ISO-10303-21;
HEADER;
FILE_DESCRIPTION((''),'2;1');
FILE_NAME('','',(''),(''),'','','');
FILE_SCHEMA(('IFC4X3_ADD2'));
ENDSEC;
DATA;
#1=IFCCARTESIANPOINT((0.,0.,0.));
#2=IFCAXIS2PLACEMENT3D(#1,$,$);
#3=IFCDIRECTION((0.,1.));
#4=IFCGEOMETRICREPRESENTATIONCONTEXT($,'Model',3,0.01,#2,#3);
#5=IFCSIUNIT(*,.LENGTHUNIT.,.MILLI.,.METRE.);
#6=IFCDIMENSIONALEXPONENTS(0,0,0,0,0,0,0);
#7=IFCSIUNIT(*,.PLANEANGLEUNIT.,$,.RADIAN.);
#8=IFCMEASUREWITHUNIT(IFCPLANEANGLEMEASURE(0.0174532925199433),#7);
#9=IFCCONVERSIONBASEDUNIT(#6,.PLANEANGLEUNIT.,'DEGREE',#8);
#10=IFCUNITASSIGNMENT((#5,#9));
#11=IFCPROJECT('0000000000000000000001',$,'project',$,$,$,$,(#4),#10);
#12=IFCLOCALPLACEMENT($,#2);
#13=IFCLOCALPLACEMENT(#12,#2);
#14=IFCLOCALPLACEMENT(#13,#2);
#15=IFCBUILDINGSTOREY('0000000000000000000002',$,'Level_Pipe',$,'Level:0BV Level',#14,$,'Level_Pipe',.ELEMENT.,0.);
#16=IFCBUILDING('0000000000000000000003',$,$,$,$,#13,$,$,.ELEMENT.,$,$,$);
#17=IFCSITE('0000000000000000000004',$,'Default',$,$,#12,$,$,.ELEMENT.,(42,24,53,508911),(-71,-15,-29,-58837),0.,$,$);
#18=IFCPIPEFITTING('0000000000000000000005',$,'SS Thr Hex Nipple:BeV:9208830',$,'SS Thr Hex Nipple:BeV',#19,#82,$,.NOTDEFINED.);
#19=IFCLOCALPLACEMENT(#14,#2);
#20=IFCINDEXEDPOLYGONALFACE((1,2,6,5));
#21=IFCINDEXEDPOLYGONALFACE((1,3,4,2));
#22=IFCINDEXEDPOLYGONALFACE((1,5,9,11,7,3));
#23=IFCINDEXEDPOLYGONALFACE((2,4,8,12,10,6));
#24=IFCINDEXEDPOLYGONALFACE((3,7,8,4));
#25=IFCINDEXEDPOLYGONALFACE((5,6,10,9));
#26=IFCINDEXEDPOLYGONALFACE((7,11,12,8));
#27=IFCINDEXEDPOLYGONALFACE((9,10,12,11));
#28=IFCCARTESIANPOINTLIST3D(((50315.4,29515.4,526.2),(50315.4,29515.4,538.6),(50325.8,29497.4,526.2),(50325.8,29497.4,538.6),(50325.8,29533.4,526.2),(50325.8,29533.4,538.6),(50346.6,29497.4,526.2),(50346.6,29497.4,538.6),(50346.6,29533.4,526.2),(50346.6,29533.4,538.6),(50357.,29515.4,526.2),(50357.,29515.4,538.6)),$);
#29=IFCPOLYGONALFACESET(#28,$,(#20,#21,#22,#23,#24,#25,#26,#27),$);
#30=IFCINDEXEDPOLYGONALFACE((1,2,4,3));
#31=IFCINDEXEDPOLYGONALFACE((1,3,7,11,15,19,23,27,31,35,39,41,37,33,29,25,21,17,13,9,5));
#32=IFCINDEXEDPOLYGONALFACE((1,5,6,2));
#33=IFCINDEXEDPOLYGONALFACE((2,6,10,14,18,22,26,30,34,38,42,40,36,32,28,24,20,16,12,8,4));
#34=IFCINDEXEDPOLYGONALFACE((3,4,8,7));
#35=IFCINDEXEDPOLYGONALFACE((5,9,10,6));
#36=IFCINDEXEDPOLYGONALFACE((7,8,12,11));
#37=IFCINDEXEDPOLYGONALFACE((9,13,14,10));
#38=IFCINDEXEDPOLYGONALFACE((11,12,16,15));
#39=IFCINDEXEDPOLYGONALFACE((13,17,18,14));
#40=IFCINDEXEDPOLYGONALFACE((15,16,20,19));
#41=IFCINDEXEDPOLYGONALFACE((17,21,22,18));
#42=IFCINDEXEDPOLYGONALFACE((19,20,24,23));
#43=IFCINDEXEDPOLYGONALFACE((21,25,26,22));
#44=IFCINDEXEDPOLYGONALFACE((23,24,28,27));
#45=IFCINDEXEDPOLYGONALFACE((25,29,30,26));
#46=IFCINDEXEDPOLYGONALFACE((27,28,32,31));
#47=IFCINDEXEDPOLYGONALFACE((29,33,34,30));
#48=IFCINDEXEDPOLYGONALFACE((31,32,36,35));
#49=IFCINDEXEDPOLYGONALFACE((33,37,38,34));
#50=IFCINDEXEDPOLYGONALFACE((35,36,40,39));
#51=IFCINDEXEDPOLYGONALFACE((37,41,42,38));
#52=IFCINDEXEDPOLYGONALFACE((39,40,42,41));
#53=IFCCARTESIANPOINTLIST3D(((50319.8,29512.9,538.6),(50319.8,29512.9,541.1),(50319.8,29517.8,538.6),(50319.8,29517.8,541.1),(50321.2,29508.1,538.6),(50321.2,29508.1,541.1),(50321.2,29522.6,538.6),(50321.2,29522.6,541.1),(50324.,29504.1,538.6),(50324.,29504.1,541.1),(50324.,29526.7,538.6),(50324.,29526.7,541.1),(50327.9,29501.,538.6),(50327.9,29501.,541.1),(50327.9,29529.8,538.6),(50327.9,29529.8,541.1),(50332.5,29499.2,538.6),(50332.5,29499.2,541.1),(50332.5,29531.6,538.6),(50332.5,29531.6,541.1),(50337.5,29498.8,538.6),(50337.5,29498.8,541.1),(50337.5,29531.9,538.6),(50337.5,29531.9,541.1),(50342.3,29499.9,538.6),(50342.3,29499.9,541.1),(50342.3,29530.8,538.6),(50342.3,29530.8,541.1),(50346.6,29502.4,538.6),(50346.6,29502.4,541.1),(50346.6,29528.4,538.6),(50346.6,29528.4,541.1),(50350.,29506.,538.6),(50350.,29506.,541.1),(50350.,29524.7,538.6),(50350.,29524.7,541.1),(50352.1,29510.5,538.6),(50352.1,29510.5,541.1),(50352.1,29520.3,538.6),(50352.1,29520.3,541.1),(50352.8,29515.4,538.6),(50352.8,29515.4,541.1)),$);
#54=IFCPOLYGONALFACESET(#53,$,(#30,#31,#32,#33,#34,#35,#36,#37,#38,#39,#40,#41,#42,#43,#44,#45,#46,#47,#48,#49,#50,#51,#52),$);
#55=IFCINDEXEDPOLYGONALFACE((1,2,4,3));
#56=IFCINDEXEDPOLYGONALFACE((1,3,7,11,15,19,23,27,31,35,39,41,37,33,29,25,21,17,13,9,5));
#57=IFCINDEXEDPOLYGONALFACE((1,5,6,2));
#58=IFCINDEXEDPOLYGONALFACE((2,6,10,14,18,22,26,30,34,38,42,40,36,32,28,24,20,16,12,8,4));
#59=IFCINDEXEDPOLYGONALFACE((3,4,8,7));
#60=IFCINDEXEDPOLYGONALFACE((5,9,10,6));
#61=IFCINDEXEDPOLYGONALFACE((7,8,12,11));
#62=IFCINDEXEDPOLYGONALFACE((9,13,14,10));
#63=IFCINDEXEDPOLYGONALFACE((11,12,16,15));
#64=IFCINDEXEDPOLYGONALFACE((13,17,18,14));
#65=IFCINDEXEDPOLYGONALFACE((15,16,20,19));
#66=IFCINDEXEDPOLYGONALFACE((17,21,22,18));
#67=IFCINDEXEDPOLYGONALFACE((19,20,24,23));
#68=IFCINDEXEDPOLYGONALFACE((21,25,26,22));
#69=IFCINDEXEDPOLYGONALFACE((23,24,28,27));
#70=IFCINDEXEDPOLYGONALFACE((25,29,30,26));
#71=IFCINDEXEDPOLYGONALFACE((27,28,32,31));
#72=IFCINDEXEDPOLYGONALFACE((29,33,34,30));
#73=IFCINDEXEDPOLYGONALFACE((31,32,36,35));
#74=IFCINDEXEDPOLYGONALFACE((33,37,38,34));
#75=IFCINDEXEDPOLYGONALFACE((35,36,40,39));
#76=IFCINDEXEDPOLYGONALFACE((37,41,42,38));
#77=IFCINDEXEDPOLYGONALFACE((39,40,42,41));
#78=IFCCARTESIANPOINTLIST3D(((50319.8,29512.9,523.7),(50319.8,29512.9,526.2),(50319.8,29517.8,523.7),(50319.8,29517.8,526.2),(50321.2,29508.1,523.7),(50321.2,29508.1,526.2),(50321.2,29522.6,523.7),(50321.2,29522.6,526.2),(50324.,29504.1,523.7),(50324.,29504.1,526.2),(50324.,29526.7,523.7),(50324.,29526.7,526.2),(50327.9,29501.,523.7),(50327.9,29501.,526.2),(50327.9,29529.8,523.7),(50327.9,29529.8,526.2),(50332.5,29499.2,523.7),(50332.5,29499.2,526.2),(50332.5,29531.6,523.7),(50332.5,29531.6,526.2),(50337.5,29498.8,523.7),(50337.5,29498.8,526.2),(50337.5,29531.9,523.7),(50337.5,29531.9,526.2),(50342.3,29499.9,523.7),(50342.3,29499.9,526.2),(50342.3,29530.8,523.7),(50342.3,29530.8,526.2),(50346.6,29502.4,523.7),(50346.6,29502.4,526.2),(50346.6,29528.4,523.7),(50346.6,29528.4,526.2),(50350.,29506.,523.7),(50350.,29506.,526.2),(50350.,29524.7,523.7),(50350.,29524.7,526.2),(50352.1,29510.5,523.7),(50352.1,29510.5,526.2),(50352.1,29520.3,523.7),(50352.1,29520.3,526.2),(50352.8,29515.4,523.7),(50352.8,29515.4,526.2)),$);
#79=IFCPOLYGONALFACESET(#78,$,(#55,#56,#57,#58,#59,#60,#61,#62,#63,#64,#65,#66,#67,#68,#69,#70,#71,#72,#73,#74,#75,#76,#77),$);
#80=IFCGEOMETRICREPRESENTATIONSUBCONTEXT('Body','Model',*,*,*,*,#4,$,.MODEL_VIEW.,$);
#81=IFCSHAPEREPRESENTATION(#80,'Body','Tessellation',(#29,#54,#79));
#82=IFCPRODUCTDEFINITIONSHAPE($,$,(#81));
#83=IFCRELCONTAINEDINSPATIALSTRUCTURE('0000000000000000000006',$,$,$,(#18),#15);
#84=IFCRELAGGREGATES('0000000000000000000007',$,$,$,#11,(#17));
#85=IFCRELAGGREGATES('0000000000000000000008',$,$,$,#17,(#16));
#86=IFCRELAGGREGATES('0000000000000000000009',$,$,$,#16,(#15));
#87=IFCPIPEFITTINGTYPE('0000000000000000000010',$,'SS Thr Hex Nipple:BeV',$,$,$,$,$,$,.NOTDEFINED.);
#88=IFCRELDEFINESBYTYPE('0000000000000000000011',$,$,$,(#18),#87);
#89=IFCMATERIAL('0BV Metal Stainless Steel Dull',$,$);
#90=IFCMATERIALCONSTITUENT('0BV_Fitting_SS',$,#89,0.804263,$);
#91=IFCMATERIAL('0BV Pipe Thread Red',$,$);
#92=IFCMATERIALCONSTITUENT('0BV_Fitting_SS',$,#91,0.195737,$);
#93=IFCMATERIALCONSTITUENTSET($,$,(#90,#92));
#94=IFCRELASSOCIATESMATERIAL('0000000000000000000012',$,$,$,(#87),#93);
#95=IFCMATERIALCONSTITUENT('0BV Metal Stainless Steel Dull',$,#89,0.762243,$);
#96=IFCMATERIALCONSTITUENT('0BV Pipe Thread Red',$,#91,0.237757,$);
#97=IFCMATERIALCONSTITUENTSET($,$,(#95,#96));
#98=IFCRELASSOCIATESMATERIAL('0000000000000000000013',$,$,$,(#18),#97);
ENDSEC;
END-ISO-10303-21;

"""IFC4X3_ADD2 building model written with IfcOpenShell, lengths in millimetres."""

from ifc_helpers import new_model, entity, si_unit, converted_unit, direction, frame, frame_2d, origin, place, context, subcontext, project, spatial, polyline, circle, outline, extrude, source, transform, mapped, material, constituent, constituent_set, type_object, type_shapes, element, save


model = new_model("IFC4X3_ADD2")

# Units and contexts
model_context = context("Model", 3, precision=0.01, world=origin(), true_north=direction((0.0, 1.0)))
body_context = subcontext(model_context, "Body", "Model", "MODEL_VIEW")
ifc_project = project(units=[si_unit("LENGTHUNIT", "METRE", prefix="MILLI"), converted_unit("PLANEANGLEUNIT", "DEGREE", entity("IfcPlaneAngleMeasure", 0.0174532925199433), si_unit("PLANEANGLEUNIT", "RADIAN"), dimensions=[0, 0, 0, 0, 0, 0, 0])], contexts=[model_context])

# Site, building, storey
site_placement = place(None, origin())
site = spatial("IfcSite", under=ifc_project, at=site_placement, Name="Default", CompositionType="ELEMENT", RefLatitude=(42, 24, 53, 508911), RefLongitude=(-71, -15, -29, -58837), RefElevation=0.0)
building_placement = place(site_placement, origin())
building = spatial("IfcBuilding", under=site, at=building_placement, CompositionType="ELEMENT")
storey_placement = place(building_placement, origin())
storey = spatial("IfcBuildingStorey", under=building, at=storey_placement, Name="Level_Pipe", ObjectType="Level:0BV Level", LongName="Level_Pipe", CompositionType="ELEMENT", Elevation=0.0)

# Shared definitions
ifc_material_1 = material(Name="0BV Metal Stainless Steel Dull")

# Pipe fitting
ifc_material_2 = material(Name="0BV Pipe Thread Red")
ifc_constituent_1 = constituent(ifc_material_1, Name="0BV Metal Stainless Steel Dull", fraction=0.762243)
ifc_constituent_2 = constituent(ifc_material_2, Name="0BV Pipe Thread Red", fraction=0.237757)
ifc_constituent_set_1 = constituent_set(constituents=[ifc_constituent_1, ifc_constituent_2])
ifc_constituent_3 = constituent(ifc_material_1, Name="0BV_Fitting_SS", fraction=0.804263)
ifc_constituent_4 = constituent(ifc_material_2, Name="0BV_Fitting_SS", fraction=0.195737)
ifc_constituent_set_2 = constituent_set(constituents=[ifc_constituent_3, ifc_constituent_4])
pipe_fitting_type_1 = type_object("IfcPipeFittingType", Name="SS Thr Hex Nipple:BeV", PredefinedType="NOTDEFINED", material=ifc_constituent_set_2)
shared_shape_1 = source(origin(), body_context, "Body", "SweptSolid", [
    extrude(outline(polyline([(-10.4, -18.0), (10.4, -18.0), (20.8, 0.0), (10.4, 18.0), (-10.4, 18.0), (-20.8, 0.0), (-10.4, -18.0)])), frame((-6.2, 0.0, 0.0), z_axis=(1.0, 0.0, 0.0), x_axis=(0.0, -0.5, -0.866025)), (0.0, 0.0, 1.0), 12.4),
    extrude(circle(Radius=16.6, at=frame_2d((0.0, 0.0), x_axis=(1.0, 0.0))), frame((6.2, 0.0, 0.0), z_axis=(1.0, 0.0, 0.0), x_axis=(0.0, 1.0, 0.0)), (0.0, 0.0, 1.0), 2.5),
    extrude(circle(Radius=16.6, at=frame_2d((0.0, 0.0), x_axis=(1.0, 0.0))), frame((-8.7, 0.0, 0.0), z_axis=(1.0, 0.0, 0.0), x_axis=(0.0, 1.0, 0.0)), (0.0, 0.0, 1.0), 2.5),
])
type_shapes(pipe_fitting_type_1, [shared_shape_1])
pipe_fitting_1_placement = place(storey_placement, frame((50336.2, 29515.4, 532.4), z_axis=(0.0, 1.0, 0.0), x_axis=(0.0, 0.0, 1.0)))
element("IfcPipeFitting", 1, at=pipe_fitting_1_placement, inside=storey, type_object=pipe_fitting_type_1, material=ifc_constituent_set_1, Name="SS Thr Hex Nipple:BeV:9208830", ObjectType="SS Thr Hex Nipple:BeV", PredefinedType="NOTDEFINED", context=body_context, shape_type="MappedRepresentation", body=[
    mapped(shared_shape_1, transform((0.0, 0.0, 0.0), scale=1.0)),
])

save(model, "model.ifc")
